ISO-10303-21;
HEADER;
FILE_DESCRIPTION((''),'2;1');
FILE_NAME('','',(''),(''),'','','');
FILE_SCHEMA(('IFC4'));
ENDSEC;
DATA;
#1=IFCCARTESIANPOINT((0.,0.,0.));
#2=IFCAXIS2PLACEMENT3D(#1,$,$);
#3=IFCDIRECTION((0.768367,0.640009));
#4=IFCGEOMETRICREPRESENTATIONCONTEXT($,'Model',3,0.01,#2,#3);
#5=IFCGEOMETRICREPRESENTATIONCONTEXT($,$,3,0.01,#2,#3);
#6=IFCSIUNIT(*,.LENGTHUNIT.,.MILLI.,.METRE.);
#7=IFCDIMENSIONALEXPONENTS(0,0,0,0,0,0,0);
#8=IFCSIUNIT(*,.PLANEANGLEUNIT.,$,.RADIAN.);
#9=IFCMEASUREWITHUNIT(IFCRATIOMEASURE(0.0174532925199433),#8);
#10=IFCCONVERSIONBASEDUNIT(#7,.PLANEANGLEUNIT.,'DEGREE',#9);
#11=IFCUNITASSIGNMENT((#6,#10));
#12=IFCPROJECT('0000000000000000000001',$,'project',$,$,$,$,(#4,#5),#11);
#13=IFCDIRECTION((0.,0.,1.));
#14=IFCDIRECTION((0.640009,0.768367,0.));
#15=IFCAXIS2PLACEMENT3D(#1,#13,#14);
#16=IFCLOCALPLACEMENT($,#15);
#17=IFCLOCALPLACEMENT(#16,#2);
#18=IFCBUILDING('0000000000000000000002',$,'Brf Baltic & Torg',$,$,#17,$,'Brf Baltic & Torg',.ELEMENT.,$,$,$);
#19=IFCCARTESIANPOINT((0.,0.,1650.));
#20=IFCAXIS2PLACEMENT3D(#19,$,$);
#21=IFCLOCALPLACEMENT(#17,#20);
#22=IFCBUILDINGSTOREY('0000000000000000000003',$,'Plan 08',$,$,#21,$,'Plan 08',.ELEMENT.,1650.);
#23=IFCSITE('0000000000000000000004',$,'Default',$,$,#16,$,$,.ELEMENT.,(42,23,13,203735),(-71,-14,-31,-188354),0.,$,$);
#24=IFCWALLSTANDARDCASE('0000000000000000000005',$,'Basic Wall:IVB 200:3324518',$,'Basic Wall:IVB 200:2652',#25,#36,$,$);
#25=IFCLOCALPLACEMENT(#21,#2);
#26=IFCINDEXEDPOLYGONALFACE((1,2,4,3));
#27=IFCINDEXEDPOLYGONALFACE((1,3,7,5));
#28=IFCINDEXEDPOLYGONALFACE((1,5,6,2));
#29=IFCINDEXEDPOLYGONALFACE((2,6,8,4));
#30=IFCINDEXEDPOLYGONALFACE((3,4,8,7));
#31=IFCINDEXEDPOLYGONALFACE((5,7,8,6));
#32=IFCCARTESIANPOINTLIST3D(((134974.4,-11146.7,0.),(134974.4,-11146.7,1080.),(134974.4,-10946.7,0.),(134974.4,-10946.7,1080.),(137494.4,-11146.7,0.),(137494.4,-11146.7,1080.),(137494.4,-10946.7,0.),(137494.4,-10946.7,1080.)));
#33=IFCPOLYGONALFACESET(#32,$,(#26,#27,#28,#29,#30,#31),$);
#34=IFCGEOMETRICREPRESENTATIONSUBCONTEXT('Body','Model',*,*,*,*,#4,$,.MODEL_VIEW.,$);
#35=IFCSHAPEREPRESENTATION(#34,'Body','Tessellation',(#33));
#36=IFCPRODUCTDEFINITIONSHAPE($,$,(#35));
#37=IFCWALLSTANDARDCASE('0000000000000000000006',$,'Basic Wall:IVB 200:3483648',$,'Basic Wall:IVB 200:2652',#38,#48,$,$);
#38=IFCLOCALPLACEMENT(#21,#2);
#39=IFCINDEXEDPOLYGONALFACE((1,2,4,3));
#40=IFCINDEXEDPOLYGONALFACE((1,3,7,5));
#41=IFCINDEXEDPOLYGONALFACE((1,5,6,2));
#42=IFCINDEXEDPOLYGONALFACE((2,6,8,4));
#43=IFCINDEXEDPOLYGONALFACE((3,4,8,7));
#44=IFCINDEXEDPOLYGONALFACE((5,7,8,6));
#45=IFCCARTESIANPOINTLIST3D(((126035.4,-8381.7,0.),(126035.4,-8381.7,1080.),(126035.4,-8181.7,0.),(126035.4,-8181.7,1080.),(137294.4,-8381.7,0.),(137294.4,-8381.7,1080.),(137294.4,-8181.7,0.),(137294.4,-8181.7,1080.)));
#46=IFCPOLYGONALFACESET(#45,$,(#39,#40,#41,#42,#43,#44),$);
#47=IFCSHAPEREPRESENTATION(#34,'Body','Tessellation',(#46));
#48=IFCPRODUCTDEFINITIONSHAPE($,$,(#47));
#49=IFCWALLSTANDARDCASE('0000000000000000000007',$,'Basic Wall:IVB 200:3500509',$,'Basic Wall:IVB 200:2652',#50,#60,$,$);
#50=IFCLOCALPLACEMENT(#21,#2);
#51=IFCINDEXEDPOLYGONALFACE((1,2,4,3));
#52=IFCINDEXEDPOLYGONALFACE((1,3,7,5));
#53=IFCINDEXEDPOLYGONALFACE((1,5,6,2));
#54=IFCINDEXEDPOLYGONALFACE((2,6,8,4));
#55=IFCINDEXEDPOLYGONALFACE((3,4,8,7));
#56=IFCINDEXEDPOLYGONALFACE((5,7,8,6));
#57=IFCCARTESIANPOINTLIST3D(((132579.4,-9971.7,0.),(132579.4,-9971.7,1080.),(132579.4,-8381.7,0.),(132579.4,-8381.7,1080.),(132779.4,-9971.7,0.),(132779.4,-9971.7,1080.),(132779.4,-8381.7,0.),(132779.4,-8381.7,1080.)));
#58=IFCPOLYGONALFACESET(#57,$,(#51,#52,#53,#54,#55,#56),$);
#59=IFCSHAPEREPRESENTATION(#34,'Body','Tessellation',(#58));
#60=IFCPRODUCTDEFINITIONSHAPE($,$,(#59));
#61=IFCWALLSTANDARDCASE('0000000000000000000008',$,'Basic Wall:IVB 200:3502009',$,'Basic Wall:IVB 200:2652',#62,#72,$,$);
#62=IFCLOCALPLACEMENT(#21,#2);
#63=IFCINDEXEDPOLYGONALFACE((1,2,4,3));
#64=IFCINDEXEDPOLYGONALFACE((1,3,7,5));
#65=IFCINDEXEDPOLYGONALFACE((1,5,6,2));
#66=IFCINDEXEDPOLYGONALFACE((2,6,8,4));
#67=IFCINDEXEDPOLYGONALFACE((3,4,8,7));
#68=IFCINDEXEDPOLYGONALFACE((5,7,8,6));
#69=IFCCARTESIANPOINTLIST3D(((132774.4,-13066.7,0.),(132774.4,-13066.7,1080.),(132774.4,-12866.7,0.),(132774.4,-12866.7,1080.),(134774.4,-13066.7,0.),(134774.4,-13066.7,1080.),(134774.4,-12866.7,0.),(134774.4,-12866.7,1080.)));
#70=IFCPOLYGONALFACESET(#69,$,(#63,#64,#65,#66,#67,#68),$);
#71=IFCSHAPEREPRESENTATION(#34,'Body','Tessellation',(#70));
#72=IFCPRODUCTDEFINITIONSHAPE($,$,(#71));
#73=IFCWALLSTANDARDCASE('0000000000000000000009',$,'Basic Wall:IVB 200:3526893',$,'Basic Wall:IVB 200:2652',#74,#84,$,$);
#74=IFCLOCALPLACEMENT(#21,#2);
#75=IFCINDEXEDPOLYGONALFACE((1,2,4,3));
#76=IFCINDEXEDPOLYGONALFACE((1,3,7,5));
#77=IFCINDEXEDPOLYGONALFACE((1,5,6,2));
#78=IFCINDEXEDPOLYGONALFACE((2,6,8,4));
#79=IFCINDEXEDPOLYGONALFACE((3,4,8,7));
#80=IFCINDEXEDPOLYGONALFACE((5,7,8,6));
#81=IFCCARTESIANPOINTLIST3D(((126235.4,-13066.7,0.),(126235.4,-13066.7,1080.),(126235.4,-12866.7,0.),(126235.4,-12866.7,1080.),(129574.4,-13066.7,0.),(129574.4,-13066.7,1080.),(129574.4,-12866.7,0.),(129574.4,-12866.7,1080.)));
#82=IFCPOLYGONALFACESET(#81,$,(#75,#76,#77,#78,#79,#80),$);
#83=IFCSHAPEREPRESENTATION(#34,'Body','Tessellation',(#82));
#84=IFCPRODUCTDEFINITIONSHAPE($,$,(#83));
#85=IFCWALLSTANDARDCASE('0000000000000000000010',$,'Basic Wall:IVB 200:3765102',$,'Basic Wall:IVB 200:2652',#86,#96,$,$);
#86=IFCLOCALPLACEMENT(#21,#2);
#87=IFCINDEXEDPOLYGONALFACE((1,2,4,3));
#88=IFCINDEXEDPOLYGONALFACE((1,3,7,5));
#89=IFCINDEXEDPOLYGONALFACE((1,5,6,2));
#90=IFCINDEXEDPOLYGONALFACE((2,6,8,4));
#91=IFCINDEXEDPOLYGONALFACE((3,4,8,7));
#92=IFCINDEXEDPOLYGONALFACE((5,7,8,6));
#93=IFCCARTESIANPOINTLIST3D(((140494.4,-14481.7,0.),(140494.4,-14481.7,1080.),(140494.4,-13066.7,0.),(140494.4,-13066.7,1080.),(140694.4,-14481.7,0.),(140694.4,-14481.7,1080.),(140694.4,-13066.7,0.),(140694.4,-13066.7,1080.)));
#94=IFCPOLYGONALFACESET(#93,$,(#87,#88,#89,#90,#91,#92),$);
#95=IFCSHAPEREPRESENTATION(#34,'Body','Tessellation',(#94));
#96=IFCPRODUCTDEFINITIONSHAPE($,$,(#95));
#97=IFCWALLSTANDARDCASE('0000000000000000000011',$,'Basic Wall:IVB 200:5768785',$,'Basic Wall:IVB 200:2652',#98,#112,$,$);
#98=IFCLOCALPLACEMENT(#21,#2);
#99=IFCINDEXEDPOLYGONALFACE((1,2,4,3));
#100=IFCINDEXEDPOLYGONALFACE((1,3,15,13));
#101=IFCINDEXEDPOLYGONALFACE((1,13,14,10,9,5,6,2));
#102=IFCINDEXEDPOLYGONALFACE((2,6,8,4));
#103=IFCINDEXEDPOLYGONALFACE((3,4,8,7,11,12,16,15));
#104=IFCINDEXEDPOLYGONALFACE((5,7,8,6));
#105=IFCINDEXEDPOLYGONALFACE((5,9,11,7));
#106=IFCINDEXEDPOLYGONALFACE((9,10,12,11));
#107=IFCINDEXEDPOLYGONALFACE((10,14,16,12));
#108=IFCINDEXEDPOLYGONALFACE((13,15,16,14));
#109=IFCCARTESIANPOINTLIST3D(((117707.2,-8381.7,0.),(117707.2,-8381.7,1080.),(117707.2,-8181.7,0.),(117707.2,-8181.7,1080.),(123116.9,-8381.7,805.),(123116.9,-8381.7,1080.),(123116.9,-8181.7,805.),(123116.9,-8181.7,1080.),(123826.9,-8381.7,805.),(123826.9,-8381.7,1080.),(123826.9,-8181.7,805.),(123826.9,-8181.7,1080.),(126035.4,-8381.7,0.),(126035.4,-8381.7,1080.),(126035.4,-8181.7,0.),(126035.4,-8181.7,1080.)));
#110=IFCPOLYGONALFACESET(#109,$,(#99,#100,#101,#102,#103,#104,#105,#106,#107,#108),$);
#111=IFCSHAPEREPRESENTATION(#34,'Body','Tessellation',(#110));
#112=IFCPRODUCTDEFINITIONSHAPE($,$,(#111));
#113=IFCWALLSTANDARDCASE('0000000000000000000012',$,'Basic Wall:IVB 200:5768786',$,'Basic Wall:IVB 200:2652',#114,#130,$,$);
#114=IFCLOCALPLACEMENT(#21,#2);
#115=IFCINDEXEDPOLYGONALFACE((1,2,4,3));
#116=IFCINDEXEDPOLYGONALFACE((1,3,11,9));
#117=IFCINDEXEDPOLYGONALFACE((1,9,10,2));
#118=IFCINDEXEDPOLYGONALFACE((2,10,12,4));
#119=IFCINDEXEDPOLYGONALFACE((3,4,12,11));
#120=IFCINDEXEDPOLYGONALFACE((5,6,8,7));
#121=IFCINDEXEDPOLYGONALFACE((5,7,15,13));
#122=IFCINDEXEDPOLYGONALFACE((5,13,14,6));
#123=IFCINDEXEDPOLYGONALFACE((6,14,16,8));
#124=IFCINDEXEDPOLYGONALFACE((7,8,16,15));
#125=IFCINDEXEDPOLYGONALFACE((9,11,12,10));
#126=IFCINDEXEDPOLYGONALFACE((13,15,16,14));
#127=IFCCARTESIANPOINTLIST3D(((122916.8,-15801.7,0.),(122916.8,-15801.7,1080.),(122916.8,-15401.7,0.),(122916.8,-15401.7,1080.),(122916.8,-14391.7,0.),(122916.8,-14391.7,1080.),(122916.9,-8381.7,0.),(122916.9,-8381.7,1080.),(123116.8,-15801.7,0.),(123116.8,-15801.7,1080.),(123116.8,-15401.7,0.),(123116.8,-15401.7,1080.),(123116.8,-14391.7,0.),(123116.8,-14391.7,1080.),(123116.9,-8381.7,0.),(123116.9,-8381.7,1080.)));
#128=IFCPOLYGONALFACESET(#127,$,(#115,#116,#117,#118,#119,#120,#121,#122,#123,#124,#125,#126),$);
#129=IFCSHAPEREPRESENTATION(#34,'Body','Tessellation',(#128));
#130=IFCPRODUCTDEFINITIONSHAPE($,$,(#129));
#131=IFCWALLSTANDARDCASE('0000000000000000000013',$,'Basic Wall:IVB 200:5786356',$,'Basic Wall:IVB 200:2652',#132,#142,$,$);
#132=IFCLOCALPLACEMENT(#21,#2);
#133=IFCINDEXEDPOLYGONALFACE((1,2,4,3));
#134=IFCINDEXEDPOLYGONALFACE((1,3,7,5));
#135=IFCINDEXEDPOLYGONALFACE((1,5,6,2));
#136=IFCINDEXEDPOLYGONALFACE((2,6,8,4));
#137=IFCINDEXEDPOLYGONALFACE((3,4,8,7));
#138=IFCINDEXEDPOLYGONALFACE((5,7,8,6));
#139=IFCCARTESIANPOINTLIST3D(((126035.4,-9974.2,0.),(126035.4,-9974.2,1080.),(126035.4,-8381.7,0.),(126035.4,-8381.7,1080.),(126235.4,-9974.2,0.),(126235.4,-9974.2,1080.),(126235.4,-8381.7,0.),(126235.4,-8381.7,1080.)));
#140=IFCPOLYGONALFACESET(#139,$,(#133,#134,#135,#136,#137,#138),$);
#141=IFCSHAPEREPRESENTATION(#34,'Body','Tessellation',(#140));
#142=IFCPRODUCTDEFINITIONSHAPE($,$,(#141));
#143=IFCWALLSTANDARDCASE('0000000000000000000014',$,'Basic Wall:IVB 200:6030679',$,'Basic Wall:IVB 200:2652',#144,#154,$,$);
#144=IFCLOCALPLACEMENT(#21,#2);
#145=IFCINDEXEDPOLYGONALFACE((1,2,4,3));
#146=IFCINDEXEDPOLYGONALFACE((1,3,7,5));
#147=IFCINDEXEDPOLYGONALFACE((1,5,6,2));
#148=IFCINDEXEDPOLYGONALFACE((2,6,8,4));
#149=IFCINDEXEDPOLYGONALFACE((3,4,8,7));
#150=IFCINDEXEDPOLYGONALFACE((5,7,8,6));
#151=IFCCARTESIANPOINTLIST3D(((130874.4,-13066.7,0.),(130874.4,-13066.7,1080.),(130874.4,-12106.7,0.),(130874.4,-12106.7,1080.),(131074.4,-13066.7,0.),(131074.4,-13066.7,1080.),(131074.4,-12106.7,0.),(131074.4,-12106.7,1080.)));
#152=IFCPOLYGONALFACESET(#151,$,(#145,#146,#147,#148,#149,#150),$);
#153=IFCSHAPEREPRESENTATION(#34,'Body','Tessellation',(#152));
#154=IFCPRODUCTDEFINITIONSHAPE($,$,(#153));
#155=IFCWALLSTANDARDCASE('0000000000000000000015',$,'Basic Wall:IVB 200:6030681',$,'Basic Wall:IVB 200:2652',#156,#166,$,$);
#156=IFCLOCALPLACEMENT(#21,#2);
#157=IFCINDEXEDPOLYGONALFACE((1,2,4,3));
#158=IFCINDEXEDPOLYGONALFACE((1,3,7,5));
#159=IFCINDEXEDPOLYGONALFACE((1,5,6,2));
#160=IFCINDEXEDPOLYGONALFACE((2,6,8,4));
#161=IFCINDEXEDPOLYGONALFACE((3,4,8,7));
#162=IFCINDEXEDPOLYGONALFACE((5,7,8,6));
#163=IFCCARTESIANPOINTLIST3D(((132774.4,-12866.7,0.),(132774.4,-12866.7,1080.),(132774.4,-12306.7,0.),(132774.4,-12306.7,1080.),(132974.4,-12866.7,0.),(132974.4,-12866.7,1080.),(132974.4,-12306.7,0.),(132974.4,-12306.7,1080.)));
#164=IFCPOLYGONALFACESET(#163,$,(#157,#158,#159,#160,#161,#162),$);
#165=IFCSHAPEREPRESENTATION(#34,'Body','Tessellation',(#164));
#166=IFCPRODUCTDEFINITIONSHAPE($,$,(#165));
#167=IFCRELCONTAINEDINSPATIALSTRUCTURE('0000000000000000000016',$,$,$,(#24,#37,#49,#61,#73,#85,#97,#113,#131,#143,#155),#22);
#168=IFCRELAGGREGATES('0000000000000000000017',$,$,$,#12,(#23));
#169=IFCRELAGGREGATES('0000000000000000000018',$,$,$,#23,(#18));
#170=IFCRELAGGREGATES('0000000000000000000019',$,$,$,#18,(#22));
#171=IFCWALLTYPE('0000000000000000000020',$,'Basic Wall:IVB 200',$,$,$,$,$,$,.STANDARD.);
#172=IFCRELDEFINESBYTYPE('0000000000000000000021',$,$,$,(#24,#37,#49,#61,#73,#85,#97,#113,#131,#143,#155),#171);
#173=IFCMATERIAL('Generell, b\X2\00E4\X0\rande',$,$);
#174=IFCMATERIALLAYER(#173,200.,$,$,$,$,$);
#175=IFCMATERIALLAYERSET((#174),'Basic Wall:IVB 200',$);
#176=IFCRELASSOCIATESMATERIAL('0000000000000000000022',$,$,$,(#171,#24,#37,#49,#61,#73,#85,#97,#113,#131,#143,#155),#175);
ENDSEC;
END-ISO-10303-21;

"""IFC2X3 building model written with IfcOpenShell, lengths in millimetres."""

from ifc_helpers import new_model, entity, si_unit, converted_unit, direction, frame, frame_2d, origin, place, context, subcontext, project, spatial, rectangle, extrude, clip, halfspace, material, layer, layer_set, layer_usage, type_object, element, save


model = new_model("IFC2X3")

# Units and contexts
model_context = context("Model", 3, precision=0.01, world=origin(), true_north=direction((0.768367, 0.640009)))
context_of_model = context(None, 3, precision=0.01, world=origin(), true_north=direction((0.768367, 0.640009)))
body_context = subcontext(model_context, "Body", "Model", "MODEL_VIEW")
ifc_project = project(units=[si_unit("LENGTHUNIT", "METRE", prefix="MILLI"), converted_unit("PLANEANGLEUNIT", "DEGREE", entity("IfcRatioMeasure", 0.0174532925199433), si_unit("PLANEANGLEUNIT", "RADIAN"), dimensions=[0, 0, 0, 0, 0, 0, 0])], contexts=[model_context, context_of_model])

# Site, building, storey
site_placement = place(None, frame((0.0, 0.0, 0.0), z_axis=(0.0, 0.0, 1.0), x_axis=(0.640009, 0.768367, 0.0)))
site = spatial("IfcSite", under=ifc_project, at=site_placement, Name="Default", CompositionType="ELEMENT", RefLatitude=(42, 23, 13, 203735), RefLongitude=(-71, -14, -31, -188354), RefElevation=0.0)
building_placement = place(site_placement, origin())
building = spatial("IfcBuilding", under=site, at=building_placement, Name="Brf Baltic & Torg", LongName="Brf Baltic & Torg", CompositionType="ELEMENT")
storey_placement = place(building_placement, frame((0.0, 0.0, 1650.0)))
storey = spatial("IfcBuildingStorey", under=building, at=storey_placement, Name="Plan 08", LongName="Plan 08", CompositionType="ELEMENT", Elevation=1650.0)

# Shared definitions
ifc_material_1 = material(Name="Generell, bärande")

# Shared definitions
ifc_layer_1 = layer(ifc_material_1, 200.0)
ifc_layer_set_1 = layer_set([ifc_layer_1], Name="Basic Wall:IVB 200")
wall_type = type_object("IfcWallType", Name="Basic Wall:IVB 200", PredefinedType="STANDARD", material=ifc_layer_set_1)

# Walls
ifc_layer_usage_1 = layer_usage(ifc_layer_set_1, "AXIS2", "NEGATIVE", 100.0)
wall_1_placement = place(storey_placement, frame((134974.4, -11046.7, 0.0)))
element("IfcWallStandardCase", 1, at=wall_1_placement, inside=storey, type_object=wall_type, material=ifc_layer_usage_1, Name="Basic Wall:IVB 200:3324518", ObjectType="Basic Wall:IVB 200:2652", context=body_context, shape_type="Clipping", body=[
    clip(extrude(rectangle(XDim=2520.0, YDim=200.0, at=frame_2d((1260.0, 0.0), x_axis=(-1.0, 0.0))), origin(), (0.0, 0.0, 1.0), 1080.0), halfspace(origin(), True)),
])
ifc_layer_usage_2 = layer_usage(ifc_layer_set_1, "AXIS2", "NEGATIVE", 100.0)
wall_2_placement = place(storey_placement, frame((126035.4, -8281.7, 0.0)))
element("IfcWallStandardCase", 2, at=wall_2_placement, inside=storey, type_object=wall_type, material=ifc_layer_usage_2, Name="Basic Wall:IVB 200:3483648", ObjectType="Basic Wall:IVB 200:2652", context=body_context, shape_type="Clipping", body=[
    clip(extrude(rectangle(XDim=11259.0, YDim=200.0, at=frame_2d((5629.5, 0.0), x_axis=(-1.0, 0.0))), origin(), (0.0, 0.0, 1.0), 1080.0), halfspace(origin(), True)),
])

# Walls
ifc_layer_usage_3 = layer_usage(ifc_layer_set_1, "AXIS2", "NEGATIVE", 100.0)
wall_3_placement = place(storey_placement, frame((132679.4, -9971.7, 0.0), z_axis=(0.0, 0.0, 1.0), x_axis=(0.0, 1.0, 0.0)))
element("IfcWallStandardCase", 3, at=wall_3_placement, inside=storey, type_object=wall_type, material=ifc_layer_usage_3, Name="Basic Wall:IVB 200:3500509", ObjectType="Basic Wall:IVB 200:2652", context=body_context, shape_type="Clipping", body=[
    clip(extrude(rectangle(XDim=1590.0, YDim=200.0, at=frame_2d((795.0, 0.0), x_axis=(-1.0, 0.0))), origin(), (0.0, 0.0, 1.0), 1080.0), halfspace(origin(), True)),
])
ifc_layer_usage_4 = layer_usage(ifc_layer_set_1, "AXIS2", "NEGATIVE", 100.0)
wall_4_placement = place(storey_placement, frame((134774.4, -12966.7, 0.0), z_axis=(0.0, 0.0, 1.0), x_axis=(-1.0, 0.0, 0.0)))
element("IfcWallStandardCase", 4, at=wall_4_placement, inside=storey, type_object=wall_type, material=ifc_layer_usage_4, Name="Basic Wall:IVB 200:3502009", ObjectType="Basic Wall:IVB 200:2652", context=body_context, shape_type="Clipping", body=[
    clip(extrude(rectangle(XDim=2000.0, YDim=200.0, at=frame_2d((1000.0, 0.0), x_axis=(-1.0, 0.0))), origin(), (0.0, 0.0, 1.0), 1080.0), halfspace(origin(), True)),
])
ifc_layer_usage_5 = layer_usage(ifc_layer_set_1, "AXIS2", "NEGATIVE", 100.0)
wall_5_placement = place(storey_placement, frame((129574.4, -12966.7, 0.0), z_axis=(0.0, 0.0, 1.0), x_axis=(-1.0, 0.0, 0.0)))
element("IfcWallStandardCase", 5, at=wall_5_placement, inside=storey, type_object=wall_type, material=ifc_layer_usage_5, Name="Basic Wall:IVB 200:3526893", ObjectType="Basic Wall:IVB 200:2652", context=body_context, shape_type="Clipping", body=[
    clip(extrude(rectangle(XDim=3339.0, YDim=200.0, at=frame_2d((1669.5, 0.0), x_axis=(-1.0, 0.0))), origin(), (0.0, 0.0, 1.0), 1080.0), halfspace(origin(), True)),
])
ifc_layer_usage_6 = layer_usage(ifc_layer_set_1, "AXIS2", "NEGATIVE", 100.0)
wall_6_placement = place(storey_placement, frame((140594.4, -13066.7, 0.0), z_axis=(0.0, 0.0, 1.0), x_axis=(0.0, -1.0, 0.0)))
element("IfcWallStandardCase", 6, at=wall_6_placement, inside=storey, type_object=wall_type, material=ifc_layer_usage_6, Name="Basic Wall:IVB 200:3765102", ObjectType="Basic Wall:IVB 200:2652", context=body_context, shape_type="Clipping", body=[
    clip(extrude(rectangle(XDim=1415.0, YDim=200.0, at=frame_2d((707.5, 0.0), x_axis=(-1.0, 0.0))), origin(), (0.0, 0.0, 1.0), 1080.0), halfspace(origin(), True)),
])

# Walls, openings
ifc_layer_usage_7 = layer_usage(ifc_layer_set_1, "AXIS2", "POSITIVE", -100.0)
wall_7_placement = place(storey_placement, frame((126035.4, -8281.7, 0.0), z_axis=(0.0, 0.0, 1.0), x_axis=(-1.0, 0.000006, 0.0)))
wall_7 = element("IfcWallStandardCase", 7, at=wall_7_placement, inside=storey, type_object=wall_type, material=ifc_layer_usage_7, Name="Basic Wall:IVB 200:5768785", ObjectType="Basic Wall:IVB 200:2652", context=body_context, shape_type="Clipping", body=[
    clip(extrude(rectangle(XDim=8328.2, YDim=200.0, at=frame_2d((4164.1, 0.0), x_axis=(-1.0, 0.0))), origin(), (0.0, 0.0, 1.0), 1080.0), halfspace(origin(), True)),
])
opening_1_placement = place(wall_7_placement, frame((126035.4, -8281.7, 0.0), z_axis=(0.0, 0.0, 1.0), x_axis=(-1.0, 0.0, 0.0)))
element("IfcOpeningElement", 8, at=opening_1_placement, cuts=wall_7, ObjectType="Opening", context=body_context, shape_type="SweptSolid", body=[
    extrude(rectangle(XDim=1710.0, YDim=710.0, at=frame_2d((0.0, 0.0), x_axis=(0.0, 1.0))), frame((123471.9, -6857.7, 1660.0), z_axis=(-0.000006, -1.0, 0.0), x_axis=(1.0, -0.000006, 0.0)), (0.0, 0.0, 1.0), 3048.0),
])
ifc_layer_usage_8 = layer_usage(ifc_layer_set_1, "AXIS2", "POSITIVE", -100.0)
wall_8_placement = place(storey_placement, frame((123016.8, -15801.7, 0.0), z_axis=(0.0, 0.0, 1.0), x_axis=(0.000006, 1.0, 0.0)))
wall_8 = element("IfcWallStandardCase", 9, at=wall_8_placement, inside=storey, type_object=wall_type, material=ifc_layer_usage_8, Name="Basic Wall:IVB 200:5768786", ObjectType="Basic Wall:IVB 200:2652", context=body_context, shape_type="Clipping", body=[
    clip(extrude(rectangle(XDim=7420.0, YDim=200.0, at=frame_2d((3710.0, 0.0), x_axis=(-1.0, 0.0))), origin(), (0.0, 0.0, 1.0), 1080.0), halfspace(origin(), True)),
])
opening_2_placement = place(wall_8_placement, frame((15801.7, 123016.8, 0.0), z_axis=(0.0, 0.0, 1.0), x_axis=(0.0, -1.0, 0.0)))
element("IfcOpeningElement", 10, at=opening_2_placement, cuts=wall_8, ObjectType="Opening", context=body_context, shape_type="SweptSolid", body=[
    extrude(rectangle(XDim=2110.0, YDim=1010.0, at=frame_2d((0.0, 0.0), x_axis=(1.0, 0.0))), frame((124440.8, -14896.7, 1055.0), z_axis=(-1.0, 0.000006, 0.0), x_axis=(0.0, 0.0, 1.0)), (0.0, 0.0, 1.0), 3048.0),
])

# Walls
ifc_layer_usage_9 = layer_usage(ifc_layer_set_1, "AXIS2", "NEGATIVE", 100.0)
wall_9_placement = place(storey_placement, frame((126135.4, -9974.2, 0.0), z_axis=(0.0, 0.0, 1.0), x_axis=(0.0, 1.0, 0.0)))
element("IfcWallStandardCase", 11, at=wall_9_placement, inside=storey, type_object=wall_type, material=ifc_layer_usage_9, Name="Basic Wall:IVB 200:5786356", ObjectType="Basic Wall:IVB 200:2652", context=body_context, shape_type="Clipping", body=[
    clip(extrude(rectangle(XDim=1592.5, YDim=200.0, at=frame_2d((796.3, 0.0), x_axis=(-1.0, 0.0))), origin(), (0.0, 0.0, 1.0), 1080.0), halfspace(origin(), True)),
])
ifc_layer_usage_10 = layer_usage(ifc_layer_set_1, "AXIS2", "POSITIVE", -100.0)
wall_10_placement = place(storey_placement, frame((130974.4, -13066.7, 0.0), z_axis=(0.0, 0.0, 1.0), x_axis=(0.0, 1.0, 0.0)))
element("IfcWallStandardCase", 12, at=wall_10_placement, inside=storey, type_object=wall_type, material=ifc_layer_usage_10, Name="Basic Wall:IVB 200:6030679", ObjectType="Basic Wall:IVB 200:2652", context=body_context, shape_type="Clipping", body=[
    clip(extrude(rectangle(XDim=960.0, YDim=200.0, at=frame_2d((480.0, 0.0), x_axis=(-1.0, 0.0))), origin(), (0.0, 0.0, 1.0), 1080.0), halfspace(origin(), True)),
])

# Wall
ifc_layer_usage_11 = layer_usage(ifc_layer_set_1, "AXIS2", "POSITIVE", -100.0)
wall_11_placement = place(storey_placement, frame((132874.4, -12866.7, 0.0), z_axis=(0.0, 0.0, 1.0), x_axis=(0.0, 1.0, 0.0)))
element("IfcWallStandardCase", 13, at=wall_11_placement, inside=storey, type_object=wall_type, material=ifc_layer_usage_11, Name="Basic Wall:IVB 200:6030681", ObjectType="Basic Wall:IVB 200:2652", context=body_context, shape_type="Clipping", body=[
    clip(extrude(rectangle(XDim=560.0, YDim=200.0, at=frame_2d((280.0, 0.0), x_axis=(-1.0, 0.0))), origin(), (0.0, 0.0, 1.0), 1080.0), halfspace(origin(), True)),
])

save(model, "model.ifc")
